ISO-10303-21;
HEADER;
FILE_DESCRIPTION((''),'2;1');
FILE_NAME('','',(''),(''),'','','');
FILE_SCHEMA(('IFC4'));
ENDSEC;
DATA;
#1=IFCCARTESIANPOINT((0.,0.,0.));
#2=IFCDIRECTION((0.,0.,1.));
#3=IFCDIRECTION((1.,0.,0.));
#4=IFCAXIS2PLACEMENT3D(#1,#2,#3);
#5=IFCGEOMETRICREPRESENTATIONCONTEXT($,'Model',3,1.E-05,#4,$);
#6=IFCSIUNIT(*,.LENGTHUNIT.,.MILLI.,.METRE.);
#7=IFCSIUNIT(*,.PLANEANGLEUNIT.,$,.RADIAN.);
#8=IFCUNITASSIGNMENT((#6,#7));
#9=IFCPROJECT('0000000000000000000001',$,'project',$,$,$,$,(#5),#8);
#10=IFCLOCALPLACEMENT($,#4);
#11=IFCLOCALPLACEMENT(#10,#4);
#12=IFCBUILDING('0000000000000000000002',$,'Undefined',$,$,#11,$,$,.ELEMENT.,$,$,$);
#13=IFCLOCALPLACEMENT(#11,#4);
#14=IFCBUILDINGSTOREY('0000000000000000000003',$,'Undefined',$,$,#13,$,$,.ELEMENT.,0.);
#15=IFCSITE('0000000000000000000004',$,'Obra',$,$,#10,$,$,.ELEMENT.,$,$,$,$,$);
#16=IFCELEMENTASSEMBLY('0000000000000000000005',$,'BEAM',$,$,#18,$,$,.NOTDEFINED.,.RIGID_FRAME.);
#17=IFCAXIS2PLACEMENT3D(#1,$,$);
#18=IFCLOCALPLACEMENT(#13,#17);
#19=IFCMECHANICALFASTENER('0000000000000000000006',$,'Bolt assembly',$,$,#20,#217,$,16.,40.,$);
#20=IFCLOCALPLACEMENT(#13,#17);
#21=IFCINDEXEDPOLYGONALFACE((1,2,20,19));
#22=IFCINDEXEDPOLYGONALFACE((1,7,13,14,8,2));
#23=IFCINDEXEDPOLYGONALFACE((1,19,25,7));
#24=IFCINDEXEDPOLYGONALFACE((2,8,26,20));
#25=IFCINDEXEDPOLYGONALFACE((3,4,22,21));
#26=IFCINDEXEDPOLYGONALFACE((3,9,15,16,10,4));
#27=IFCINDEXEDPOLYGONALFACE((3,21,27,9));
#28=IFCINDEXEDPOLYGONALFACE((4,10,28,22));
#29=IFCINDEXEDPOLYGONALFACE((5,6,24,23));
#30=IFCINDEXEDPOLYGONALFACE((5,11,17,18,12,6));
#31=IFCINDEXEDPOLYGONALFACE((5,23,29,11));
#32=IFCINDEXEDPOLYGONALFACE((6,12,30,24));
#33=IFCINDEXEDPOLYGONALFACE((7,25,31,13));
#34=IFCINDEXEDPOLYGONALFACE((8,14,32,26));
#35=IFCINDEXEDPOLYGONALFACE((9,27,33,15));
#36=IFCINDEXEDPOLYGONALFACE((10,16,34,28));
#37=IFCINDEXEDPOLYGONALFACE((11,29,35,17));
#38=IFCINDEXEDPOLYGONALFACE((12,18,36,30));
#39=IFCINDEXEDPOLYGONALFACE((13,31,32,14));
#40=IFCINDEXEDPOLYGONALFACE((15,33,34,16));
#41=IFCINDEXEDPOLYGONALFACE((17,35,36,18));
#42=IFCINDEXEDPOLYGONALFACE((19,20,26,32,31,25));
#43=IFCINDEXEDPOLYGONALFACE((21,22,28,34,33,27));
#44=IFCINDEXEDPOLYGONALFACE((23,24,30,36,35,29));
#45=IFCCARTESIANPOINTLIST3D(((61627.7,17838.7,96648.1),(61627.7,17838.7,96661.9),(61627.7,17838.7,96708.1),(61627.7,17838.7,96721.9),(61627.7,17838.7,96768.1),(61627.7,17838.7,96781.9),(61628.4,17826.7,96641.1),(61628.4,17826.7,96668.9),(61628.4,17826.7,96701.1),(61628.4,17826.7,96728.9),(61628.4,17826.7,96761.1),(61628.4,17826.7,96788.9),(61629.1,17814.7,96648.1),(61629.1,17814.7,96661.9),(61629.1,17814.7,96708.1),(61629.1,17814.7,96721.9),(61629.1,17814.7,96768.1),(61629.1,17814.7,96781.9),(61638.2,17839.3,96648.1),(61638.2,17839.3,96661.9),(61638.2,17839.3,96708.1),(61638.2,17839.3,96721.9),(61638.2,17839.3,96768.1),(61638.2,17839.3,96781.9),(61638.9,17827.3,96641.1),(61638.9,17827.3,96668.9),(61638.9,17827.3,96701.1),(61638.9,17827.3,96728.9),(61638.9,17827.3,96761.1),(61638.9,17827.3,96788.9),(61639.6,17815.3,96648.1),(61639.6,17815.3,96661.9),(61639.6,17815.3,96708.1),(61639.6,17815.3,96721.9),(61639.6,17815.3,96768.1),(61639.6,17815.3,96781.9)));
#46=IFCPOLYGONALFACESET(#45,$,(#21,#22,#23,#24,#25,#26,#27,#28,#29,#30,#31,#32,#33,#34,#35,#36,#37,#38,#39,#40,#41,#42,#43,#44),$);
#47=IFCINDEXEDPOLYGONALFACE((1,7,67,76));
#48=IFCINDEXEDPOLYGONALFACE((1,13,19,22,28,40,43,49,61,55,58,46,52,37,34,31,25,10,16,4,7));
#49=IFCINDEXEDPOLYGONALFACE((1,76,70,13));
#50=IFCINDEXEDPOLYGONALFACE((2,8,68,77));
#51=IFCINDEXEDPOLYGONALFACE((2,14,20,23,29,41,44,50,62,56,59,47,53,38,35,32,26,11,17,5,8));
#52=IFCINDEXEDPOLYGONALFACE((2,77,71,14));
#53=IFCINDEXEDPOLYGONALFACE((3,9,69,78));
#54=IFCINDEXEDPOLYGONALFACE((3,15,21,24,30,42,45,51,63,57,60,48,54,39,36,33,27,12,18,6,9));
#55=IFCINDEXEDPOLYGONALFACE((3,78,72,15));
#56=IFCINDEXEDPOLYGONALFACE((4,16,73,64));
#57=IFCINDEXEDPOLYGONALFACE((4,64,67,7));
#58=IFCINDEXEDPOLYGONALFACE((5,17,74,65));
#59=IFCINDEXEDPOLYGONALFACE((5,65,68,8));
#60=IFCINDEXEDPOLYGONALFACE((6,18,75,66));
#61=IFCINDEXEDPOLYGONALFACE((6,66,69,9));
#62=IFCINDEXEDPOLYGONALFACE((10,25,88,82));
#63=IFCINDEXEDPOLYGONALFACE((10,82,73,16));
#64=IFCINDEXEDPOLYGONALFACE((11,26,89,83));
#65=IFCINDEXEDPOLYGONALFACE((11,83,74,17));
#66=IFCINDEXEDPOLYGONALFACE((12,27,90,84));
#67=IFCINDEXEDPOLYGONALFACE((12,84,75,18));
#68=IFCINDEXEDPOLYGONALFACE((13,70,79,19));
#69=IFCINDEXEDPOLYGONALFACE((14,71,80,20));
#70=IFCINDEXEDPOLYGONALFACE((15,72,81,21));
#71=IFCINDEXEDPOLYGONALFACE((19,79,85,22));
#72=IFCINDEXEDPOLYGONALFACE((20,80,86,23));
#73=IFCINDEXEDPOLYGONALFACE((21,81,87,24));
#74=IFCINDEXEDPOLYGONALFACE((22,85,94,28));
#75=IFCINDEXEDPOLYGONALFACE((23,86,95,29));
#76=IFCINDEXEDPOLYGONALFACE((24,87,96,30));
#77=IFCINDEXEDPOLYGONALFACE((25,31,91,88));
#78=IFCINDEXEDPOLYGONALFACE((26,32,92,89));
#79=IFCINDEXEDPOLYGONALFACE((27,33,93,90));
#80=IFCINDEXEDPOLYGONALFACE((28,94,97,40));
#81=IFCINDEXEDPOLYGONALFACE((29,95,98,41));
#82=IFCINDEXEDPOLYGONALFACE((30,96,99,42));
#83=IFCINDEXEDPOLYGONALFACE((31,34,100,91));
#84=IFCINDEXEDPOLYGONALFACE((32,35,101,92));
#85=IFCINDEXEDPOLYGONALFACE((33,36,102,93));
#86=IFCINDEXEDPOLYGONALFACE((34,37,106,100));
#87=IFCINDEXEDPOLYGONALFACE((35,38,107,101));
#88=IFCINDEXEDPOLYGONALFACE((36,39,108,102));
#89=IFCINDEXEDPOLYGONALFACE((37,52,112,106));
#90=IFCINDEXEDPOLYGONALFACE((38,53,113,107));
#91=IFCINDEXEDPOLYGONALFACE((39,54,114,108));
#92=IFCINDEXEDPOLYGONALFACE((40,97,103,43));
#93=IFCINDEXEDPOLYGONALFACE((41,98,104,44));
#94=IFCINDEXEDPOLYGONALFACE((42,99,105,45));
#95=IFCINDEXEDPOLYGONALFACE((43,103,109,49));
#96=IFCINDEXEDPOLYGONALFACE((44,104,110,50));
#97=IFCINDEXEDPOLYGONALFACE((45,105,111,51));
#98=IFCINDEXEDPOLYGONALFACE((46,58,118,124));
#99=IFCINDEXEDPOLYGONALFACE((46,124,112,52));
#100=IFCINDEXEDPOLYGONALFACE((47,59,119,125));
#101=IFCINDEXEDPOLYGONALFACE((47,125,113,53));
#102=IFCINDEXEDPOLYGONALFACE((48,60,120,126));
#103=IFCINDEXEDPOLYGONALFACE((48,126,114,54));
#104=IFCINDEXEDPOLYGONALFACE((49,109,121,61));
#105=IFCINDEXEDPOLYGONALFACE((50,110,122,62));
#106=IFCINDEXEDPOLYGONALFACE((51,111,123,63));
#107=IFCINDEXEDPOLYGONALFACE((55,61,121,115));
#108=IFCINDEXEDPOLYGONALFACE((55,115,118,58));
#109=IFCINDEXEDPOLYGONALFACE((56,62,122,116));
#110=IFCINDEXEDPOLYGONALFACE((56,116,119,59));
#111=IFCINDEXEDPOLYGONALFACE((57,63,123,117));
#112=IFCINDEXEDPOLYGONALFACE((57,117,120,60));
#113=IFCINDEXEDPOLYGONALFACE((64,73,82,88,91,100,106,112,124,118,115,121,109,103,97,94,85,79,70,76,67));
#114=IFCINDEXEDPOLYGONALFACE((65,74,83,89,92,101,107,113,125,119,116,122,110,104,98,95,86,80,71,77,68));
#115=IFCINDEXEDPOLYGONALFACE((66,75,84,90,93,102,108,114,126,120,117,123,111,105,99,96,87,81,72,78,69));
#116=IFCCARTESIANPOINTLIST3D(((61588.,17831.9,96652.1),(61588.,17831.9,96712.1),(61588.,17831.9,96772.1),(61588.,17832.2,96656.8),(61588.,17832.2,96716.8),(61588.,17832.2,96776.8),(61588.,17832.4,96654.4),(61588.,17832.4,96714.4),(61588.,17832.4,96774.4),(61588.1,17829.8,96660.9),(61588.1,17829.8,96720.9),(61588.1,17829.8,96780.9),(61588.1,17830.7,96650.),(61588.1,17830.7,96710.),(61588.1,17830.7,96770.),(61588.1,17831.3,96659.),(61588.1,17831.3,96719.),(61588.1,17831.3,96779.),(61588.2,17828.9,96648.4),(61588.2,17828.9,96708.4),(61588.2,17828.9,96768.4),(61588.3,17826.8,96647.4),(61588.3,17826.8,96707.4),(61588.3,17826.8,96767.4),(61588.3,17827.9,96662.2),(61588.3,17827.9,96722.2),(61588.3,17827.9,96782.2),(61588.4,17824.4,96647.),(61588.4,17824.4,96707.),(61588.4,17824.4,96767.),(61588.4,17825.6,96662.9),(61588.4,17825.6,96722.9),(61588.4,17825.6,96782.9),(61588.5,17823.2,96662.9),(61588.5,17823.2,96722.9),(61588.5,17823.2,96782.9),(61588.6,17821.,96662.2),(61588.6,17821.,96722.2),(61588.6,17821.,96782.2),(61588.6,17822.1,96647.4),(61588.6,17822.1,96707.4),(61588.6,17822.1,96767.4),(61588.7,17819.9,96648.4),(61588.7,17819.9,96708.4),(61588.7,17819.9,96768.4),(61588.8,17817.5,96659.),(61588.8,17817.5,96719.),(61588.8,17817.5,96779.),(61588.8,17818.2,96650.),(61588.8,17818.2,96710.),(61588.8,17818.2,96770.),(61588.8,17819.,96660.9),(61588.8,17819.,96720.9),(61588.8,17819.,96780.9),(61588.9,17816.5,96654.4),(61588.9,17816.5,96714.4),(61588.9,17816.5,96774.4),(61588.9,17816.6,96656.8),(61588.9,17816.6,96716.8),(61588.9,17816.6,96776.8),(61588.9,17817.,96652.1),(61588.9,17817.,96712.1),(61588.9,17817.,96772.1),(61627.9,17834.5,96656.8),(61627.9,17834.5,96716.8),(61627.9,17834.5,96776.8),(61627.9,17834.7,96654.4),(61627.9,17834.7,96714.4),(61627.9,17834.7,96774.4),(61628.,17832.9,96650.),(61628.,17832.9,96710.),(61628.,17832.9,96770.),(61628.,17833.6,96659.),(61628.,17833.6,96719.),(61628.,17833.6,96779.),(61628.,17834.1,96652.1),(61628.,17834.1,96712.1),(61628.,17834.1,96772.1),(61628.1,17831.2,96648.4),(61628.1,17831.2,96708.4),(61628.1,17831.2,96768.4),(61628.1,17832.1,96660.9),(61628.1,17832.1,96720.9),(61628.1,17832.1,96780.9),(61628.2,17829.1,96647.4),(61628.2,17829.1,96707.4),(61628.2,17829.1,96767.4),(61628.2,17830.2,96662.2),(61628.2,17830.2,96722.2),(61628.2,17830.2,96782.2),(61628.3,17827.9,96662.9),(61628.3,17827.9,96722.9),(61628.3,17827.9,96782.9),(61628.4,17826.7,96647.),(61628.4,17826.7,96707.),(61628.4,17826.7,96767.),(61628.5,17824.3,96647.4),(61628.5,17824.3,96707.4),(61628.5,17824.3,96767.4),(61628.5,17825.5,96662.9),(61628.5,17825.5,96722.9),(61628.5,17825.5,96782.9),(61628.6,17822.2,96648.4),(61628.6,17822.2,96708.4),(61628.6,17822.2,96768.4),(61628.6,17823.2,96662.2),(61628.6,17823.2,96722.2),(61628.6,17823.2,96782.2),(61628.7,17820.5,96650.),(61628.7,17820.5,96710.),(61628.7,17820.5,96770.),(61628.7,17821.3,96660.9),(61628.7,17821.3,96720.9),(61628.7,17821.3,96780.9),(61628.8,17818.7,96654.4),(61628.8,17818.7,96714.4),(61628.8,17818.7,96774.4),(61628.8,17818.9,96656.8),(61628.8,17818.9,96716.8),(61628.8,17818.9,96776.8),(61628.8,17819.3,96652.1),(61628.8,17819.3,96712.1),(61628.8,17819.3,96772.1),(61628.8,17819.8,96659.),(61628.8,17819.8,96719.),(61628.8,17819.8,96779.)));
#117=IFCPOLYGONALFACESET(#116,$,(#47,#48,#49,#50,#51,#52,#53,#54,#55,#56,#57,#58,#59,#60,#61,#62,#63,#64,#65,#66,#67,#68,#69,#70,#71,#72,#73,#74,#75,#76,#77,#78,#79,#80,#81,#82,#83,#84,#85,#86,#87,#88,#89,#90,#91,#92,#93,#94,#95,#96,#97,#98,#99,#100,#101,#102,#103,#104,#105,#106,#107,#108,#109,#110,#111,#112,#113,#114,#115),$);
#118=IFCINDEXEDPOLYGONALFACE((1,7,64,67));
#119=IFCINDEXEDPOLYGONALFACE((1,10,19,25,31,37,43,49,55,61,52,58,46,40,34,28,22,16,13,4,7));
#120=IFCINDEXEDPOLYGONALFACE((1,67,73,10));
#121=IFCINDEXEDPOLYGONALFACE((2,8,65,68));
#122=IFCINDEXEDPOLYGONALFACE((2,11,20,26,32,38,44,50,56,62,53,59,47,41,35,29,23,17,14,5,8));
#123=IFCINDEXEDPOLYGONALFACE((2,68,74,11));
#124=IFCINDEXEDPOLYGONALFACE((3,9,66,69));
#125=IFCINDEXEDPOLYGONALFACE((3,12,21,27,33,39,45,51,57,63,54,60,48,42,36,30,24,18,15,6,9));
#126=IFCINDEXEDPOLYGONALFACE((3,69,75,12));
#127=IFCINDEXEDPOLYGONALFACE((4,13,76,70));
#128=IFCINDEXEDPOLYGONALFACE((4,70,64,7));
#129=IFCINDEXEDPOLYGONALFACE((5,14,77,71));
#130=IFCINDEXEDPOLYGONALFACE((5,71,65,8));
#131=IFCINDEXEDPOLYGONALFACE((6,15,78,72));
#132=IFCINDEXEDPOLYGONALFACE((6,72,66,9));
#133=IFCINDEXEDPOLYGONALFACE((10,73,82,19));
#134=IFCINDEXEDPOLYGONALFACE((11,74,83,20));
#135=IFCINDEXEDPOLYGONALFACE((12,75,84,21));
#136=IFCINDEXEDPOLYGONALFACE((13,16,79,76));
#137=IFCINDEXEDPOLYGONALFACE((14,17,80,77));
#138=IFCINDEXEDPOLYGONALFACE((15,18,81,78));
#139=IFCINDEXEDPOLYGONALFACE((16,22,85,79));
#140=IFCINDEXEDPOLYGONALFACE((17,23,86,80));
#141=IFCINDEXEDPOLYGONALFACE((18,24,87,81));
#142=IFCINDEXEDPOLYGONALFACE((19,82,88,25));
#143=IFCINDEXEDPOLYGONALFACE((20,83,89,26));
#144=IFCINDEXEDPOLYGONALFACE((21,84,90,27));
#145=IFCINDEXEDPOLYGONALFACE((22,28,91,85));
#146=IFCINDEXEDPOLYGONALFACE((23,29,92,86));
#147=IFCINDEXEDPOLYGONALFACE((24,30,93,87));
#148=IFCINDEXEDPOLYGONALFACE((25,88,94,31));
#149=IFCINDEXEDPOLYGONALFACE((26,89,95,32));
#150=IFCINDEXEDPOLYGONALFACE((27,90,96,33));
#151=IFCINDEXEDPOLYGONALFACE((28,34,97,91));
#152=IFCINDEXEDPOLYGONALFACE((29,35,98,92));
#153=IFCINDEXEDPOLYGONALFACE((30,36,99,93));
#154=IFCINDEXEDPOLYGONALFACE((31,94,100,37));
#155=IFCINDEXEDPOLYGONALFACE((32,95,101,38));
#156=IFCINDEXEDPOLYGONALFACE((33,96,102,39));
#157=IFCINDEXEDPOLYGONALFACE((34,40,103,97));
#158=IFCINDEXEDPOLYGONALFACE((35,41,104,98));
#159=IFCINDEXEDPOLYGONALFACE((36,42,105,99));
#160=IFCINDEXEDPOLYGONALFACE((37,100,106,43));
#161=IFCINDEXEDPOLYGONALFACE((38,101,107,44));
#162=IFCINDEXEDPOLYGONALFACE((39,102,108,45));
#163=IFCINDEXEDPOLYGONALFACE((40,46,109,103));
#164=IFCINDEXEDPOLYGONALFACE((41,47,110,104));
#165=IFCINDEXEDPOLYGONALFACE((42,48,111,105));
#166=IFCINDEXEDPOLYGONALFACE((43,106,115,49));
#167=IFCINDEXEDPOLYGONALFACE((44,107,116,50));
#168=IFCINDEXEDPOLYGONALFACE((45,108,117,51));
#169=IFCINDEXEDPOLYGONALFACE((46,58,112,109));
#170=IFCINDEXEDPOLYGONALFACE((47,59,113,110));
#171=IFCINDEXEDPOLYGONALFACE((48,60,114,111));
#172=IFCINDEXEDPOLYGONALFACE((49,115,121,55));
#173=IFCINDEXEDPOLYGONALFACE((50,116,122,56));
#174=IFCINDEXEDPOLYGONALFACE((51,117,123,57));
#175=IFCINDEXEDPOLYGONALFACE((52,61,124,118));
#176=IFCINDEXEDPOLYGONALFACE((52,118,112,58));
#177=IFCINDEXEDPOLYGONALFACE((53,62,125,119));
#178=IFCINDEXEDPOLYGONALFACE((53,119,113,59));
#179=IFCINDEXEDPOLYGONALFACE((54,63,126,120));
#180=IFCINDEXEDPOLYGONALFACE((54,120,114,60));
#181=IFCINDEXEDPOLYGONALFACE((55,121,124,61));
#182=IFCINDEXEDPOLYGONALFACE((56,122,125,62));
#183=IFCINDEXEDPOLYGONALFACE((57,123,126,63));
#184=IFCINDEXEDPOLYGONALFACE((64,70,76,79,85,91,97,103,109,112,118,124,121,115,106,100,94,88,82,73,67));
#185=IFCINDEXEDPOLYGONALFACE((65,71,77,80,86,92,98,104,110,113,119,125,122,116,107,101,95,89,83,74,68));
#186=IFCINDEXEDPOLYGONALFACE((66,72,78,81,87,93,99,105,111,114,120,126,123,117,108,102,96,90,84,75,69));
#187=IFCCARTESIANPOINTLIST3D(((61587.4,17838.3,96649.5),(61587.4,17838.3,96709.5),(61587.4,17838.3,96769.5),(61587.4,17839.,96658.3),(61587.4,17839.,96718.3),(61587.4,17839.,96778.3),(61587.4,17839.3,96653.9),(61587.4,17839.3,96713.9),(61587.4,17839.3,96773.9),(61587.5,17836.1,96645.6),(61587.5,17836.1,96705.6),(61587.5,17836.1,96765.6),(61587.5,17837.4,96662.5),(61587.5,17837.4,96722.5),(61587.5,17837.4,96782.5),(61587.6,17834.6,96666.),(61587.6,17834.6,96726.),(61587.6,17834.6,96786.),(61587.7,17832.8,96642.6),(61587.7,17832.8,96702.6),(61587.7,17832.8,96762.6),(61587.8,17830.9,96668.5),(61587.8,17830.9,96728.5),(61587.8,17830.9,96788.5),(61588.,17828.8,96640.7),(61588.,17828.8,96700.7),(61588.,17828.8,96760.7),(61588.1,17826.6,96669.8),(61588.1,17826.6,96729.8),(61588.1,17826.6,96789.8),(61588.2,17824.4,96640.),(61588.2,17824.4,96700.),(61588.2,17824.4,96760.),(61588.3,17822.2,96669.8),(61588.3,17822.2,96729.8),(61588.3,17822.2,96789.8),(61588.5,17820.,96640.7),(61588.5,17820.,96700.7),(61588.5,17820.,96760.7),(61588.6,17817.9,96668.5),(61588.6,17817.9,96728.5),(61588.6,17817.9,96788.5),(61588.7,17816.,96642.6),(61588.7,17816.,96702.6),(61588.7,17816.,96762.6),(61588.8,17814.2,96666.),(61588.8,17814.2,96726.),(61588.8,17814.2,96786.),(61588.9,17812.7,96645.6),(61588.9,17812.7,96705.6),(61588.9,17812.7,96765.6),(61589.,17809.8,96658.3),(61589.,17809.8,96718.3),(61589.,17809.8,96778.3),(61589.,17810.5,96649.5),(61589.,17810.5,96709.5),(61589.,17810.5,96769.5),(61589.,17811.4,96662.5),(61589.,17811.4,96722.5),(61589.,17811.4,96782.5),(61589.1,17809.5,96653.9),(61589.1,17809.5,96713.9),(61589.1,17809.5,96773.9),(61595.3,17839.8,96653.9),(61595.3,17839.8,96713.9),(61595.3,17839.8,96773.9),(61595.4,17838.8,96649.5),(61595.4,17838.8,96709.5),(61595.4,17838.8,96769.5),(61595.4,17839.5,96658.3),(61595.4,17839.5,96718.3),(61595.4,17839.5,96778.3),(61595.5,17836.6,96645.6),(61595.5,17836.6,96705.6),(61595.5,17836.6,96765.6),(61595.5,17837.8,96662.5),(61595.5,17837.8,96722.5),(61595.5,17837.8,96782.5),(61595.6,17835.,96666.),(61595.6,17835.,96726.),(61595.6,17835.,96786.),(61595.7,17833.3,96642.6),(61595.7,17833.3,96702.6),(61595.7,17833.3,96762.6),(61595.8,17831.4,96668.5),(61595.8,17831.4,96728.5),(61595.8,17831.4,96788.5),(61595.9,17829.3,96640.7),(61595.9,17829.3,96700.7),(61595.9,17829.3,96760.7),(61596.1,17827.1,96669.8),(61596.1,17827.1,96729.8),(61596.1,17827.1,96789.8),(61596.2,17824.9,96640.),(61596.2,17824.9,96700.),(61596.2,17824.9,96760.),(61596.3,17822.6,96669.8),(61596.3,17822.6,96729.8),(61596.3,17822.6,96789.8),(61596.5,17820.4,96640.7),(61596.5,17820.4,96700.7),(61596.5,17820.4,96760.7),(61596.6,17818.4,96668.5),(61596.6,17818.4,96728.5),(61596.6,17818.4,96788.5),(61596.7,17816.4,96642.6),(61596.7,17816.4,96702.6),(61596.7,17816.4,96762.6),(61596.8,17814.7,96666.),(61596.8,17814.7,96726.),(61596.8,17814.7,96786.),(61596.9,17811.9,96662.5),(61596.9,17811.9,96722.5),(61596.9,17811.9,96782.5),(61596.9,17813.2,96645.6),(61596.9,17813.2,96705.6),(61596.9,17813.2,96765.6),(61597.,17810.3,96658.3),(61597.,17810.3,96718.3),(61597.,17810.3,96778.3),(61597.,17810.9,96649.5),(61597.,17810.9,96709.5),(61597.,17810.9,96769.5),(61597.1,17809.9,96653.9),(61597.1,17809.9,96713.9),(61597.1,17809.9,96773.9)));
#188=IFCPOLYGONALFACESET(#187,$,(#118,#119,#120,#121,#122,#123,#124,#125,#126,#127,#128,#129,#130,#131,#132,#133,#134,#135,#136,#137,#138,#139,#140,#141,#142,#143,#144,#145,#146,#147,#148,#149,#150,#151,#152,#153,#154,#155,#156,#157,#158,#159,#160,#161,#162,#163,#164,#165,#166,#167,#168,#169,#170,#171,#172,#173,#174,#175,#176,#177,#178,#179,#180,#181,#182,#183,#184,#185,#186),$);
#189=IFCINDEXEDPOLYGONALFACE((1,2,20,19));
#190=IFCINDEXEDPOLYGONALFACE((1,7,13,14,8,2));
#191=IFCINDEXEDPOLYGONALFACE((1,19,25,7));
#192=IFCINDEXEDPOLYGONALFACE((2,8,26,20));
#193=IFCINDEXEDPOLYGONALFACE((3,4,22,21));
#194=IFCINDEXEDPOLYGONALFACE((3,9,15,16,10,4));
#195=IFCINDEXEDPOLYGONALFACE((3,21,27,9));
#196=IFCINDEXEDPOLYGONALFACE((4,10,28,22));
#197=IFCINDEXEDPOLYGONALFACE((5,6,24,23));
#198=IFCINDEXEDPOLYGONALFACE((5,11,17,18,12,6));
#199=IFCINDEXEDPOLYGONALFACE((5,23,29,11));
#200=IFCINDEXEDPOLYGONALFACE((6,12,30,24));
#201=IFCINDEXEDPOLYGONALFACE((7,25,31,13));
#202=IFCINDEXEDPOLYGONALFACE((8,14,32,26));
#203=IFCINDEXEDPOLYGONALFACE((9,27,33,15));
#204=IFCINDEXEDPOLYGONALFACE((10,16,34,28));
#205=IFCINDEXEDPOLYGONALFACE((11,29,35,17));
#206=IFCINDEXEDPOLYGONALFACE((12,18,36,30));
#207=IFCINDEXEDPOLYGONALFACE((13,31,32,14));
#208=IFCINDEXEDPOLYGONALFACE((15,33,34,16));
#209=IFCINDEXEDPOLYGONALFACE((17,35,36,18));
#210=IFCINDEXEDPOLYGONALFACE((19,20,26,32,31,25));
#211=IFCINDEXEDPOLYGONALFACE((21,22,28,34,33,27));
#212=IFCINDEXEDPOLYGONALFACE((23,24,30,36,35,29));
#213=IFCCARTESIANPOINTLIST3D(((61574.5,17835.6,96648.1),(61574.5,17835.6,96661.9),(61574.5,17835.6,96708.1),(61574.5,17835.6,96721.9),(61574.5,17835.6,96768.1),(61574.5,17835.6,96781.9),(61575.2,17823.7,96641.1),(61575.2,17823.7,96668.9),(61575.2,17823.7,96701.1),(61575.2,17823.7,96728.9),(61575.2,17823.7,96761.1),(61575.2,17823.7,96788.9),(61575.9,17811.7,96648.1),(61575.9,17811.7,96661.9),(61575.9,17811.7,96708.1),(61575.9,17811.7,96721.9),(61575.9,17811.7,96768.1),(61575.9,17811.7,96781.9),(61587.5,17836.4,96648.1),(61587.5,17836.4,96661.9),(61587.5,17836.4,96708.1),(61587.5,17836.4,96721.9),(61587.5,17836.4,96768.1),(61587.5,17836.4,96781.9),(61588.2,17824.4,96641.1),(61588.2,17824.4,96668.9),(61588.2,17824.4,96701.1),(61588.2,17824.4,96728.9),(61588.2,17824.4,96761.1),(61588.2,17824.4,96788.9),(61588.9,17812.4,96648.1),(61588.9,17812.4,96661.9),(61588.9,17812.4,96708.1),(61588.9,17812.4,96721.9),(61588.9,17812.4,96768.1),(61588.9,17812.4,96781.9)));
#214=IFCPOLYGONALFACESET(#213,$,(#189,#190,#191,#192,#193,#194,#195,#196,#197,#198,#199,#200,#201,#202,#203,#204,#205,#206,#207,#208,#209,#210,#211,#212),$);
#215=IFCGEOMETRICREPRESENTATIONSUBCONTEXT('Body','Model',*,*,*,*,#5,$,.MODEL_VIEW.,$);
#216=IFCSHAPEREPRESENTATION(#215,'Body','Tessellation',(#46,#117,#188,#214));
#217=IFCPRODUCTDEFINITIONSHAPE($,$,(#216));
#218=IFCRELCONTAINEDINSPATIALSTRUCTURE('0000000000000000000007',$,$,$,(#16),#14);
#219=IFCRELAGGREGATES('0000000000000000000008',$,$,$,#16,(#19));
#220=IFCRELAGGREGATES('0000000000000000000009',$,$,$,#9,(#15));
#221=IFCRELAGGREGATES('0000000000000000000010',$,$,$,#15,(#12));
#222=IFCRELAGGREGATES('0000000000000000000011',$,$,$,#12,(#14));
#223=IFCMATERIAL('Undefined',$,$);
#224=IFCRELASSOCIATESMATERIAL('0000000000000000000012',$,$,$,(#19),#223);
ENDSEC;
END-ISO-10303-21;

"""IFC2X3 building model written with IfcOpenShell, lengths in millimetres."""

from ifc_helpers import new_model, si_unit, frame, origin_with_axes, origin_2d_with_axis, place, context, subcontext, project, spatial, polyline, circle, outline, extrude, source, transform, mapped, material, element, aggregate, save


model = new_model("IFC2X3")

# Units and contexts
model_context = context("Model", 3, precision=1e-05, world=origin_with_axes())
body_context = subcontext(model_context, "Body", "Model", "MODEL_VIEW")
ifc_project = project(units=[si_unit("LENGTHUNIT", "METRE", prefix="MILLI"), si_unit("PLANEANGLEUNIT", "RADIAN")], contexts=[model_context])

# Site, building, storey
site_placement = place(None, origin_with_axes())
site = spatial("IfcSite", under=ifc_project, at=site_placement, Name="Obra", CompositionType="ELEMENT")
building_placement = place(site_placement, origin_with_axes())
building = spatial("IfcBuilding", under=site, at=building_placement, Name="Undefined", CompositionType="ELEMENT")
storey_placement = place(building_placement, origin_with_axes())
storey = spatial("IfcBuildingStorey", under=building, at=storey_placement, Name="Undefined", CompositionType="ELEMENT", Elevation=0.0)

# Shared definitions
ifc_material_1 = material(Name="Undefined")

# Element assembly
assembly_1_placement = place(storey_placement, origin_with_axes())
assembly_1 = element("IfcElementAssembly", 1, at=assembly_1_placement, inside=storey, Name="BEAM", AssemblyPlace="NOTDEFINED", PredefinedType="RIGID_FRAME")

# Mechanical fastener
shared_shape_1 = source(origin_with_axes(), body_context, "Body", "SweptSolid", [
    extrude(outline(polyline([(13.9, 0.0), (6.9, 12.0), (-6.9, 12.0), (-13.9, 0.0), (-6.9, -12.0), (6.9, -12.0), (13.9, 0.0)])), frame((0.0, -45.9, 0.0), z_axis=(0.0, 1.0, 0.0), x_axis=(1.0, 0.0, 0.0)), (0.0, 0.0, 1.0), 10.6),
    extrude(circle(Radius=8.0, at=origin_2d_with_axis()), frame((0.0, -35.3, 0.0), z_axis=(0.0, 1.0, 0.0), x_axis=(1.0, 0.0, 0.0)), (0.0, 0.0, 1.0), 40.0),
    extrude(circle(Radius=15.0, at=origin_2d_with_axis()), frame((0.0, -3.1, 0.0), z_axis=(0.0, 1.0, 0.0), x_axis=(1.0, 0.0, 0.0)), (0.0, 0.0, 1.0), 8.0),
    extrude(outline(polyline([(13.9, 0.0), (6.9, 12.0), (-6.9, 12.0), (-13.9, 0.0), (-6.9, -12.0), (6.9, -12.0), (13.9, 0.0)])), frame((0.0, 4.9, 0.0), z_axis=(0.0, 1.0, 0.0), x_axis=(1.0, 0.0, 0.0)), (0.0, 0.0, 1.0), 13.0),
])
mechanical_fastener_1_placement = place(assembly_1_placement, frame((61596.0, 17774.8, 96835.0), z_axis=(-0.057107, 0.998368, 0.0), x_axis=(0.0, 0.0, -1.0)))
mechanical_fastener_1 = element("IfcMechanicalFastener", 2, at=mechanical_fastener_1_placement, material=ifc_material_1, Name="Bolt assembly", NominalDiameter=16.0, NominalLength=40.0, context=body_context, shape_type="MappedRepresentation", body=[
    mapped(shared_shape_1, transform((60.0, 0.0, 50.0))),
    mapped(shared_shape_1, transform((120.0, 0.0, 50.0))),
    mapped(shared_shape_1, transform((180.0, 0.0, 50.0))),
])
aggregate(assembly_1, [mechanical_fastener_1])

save(model, "model.ifc")
